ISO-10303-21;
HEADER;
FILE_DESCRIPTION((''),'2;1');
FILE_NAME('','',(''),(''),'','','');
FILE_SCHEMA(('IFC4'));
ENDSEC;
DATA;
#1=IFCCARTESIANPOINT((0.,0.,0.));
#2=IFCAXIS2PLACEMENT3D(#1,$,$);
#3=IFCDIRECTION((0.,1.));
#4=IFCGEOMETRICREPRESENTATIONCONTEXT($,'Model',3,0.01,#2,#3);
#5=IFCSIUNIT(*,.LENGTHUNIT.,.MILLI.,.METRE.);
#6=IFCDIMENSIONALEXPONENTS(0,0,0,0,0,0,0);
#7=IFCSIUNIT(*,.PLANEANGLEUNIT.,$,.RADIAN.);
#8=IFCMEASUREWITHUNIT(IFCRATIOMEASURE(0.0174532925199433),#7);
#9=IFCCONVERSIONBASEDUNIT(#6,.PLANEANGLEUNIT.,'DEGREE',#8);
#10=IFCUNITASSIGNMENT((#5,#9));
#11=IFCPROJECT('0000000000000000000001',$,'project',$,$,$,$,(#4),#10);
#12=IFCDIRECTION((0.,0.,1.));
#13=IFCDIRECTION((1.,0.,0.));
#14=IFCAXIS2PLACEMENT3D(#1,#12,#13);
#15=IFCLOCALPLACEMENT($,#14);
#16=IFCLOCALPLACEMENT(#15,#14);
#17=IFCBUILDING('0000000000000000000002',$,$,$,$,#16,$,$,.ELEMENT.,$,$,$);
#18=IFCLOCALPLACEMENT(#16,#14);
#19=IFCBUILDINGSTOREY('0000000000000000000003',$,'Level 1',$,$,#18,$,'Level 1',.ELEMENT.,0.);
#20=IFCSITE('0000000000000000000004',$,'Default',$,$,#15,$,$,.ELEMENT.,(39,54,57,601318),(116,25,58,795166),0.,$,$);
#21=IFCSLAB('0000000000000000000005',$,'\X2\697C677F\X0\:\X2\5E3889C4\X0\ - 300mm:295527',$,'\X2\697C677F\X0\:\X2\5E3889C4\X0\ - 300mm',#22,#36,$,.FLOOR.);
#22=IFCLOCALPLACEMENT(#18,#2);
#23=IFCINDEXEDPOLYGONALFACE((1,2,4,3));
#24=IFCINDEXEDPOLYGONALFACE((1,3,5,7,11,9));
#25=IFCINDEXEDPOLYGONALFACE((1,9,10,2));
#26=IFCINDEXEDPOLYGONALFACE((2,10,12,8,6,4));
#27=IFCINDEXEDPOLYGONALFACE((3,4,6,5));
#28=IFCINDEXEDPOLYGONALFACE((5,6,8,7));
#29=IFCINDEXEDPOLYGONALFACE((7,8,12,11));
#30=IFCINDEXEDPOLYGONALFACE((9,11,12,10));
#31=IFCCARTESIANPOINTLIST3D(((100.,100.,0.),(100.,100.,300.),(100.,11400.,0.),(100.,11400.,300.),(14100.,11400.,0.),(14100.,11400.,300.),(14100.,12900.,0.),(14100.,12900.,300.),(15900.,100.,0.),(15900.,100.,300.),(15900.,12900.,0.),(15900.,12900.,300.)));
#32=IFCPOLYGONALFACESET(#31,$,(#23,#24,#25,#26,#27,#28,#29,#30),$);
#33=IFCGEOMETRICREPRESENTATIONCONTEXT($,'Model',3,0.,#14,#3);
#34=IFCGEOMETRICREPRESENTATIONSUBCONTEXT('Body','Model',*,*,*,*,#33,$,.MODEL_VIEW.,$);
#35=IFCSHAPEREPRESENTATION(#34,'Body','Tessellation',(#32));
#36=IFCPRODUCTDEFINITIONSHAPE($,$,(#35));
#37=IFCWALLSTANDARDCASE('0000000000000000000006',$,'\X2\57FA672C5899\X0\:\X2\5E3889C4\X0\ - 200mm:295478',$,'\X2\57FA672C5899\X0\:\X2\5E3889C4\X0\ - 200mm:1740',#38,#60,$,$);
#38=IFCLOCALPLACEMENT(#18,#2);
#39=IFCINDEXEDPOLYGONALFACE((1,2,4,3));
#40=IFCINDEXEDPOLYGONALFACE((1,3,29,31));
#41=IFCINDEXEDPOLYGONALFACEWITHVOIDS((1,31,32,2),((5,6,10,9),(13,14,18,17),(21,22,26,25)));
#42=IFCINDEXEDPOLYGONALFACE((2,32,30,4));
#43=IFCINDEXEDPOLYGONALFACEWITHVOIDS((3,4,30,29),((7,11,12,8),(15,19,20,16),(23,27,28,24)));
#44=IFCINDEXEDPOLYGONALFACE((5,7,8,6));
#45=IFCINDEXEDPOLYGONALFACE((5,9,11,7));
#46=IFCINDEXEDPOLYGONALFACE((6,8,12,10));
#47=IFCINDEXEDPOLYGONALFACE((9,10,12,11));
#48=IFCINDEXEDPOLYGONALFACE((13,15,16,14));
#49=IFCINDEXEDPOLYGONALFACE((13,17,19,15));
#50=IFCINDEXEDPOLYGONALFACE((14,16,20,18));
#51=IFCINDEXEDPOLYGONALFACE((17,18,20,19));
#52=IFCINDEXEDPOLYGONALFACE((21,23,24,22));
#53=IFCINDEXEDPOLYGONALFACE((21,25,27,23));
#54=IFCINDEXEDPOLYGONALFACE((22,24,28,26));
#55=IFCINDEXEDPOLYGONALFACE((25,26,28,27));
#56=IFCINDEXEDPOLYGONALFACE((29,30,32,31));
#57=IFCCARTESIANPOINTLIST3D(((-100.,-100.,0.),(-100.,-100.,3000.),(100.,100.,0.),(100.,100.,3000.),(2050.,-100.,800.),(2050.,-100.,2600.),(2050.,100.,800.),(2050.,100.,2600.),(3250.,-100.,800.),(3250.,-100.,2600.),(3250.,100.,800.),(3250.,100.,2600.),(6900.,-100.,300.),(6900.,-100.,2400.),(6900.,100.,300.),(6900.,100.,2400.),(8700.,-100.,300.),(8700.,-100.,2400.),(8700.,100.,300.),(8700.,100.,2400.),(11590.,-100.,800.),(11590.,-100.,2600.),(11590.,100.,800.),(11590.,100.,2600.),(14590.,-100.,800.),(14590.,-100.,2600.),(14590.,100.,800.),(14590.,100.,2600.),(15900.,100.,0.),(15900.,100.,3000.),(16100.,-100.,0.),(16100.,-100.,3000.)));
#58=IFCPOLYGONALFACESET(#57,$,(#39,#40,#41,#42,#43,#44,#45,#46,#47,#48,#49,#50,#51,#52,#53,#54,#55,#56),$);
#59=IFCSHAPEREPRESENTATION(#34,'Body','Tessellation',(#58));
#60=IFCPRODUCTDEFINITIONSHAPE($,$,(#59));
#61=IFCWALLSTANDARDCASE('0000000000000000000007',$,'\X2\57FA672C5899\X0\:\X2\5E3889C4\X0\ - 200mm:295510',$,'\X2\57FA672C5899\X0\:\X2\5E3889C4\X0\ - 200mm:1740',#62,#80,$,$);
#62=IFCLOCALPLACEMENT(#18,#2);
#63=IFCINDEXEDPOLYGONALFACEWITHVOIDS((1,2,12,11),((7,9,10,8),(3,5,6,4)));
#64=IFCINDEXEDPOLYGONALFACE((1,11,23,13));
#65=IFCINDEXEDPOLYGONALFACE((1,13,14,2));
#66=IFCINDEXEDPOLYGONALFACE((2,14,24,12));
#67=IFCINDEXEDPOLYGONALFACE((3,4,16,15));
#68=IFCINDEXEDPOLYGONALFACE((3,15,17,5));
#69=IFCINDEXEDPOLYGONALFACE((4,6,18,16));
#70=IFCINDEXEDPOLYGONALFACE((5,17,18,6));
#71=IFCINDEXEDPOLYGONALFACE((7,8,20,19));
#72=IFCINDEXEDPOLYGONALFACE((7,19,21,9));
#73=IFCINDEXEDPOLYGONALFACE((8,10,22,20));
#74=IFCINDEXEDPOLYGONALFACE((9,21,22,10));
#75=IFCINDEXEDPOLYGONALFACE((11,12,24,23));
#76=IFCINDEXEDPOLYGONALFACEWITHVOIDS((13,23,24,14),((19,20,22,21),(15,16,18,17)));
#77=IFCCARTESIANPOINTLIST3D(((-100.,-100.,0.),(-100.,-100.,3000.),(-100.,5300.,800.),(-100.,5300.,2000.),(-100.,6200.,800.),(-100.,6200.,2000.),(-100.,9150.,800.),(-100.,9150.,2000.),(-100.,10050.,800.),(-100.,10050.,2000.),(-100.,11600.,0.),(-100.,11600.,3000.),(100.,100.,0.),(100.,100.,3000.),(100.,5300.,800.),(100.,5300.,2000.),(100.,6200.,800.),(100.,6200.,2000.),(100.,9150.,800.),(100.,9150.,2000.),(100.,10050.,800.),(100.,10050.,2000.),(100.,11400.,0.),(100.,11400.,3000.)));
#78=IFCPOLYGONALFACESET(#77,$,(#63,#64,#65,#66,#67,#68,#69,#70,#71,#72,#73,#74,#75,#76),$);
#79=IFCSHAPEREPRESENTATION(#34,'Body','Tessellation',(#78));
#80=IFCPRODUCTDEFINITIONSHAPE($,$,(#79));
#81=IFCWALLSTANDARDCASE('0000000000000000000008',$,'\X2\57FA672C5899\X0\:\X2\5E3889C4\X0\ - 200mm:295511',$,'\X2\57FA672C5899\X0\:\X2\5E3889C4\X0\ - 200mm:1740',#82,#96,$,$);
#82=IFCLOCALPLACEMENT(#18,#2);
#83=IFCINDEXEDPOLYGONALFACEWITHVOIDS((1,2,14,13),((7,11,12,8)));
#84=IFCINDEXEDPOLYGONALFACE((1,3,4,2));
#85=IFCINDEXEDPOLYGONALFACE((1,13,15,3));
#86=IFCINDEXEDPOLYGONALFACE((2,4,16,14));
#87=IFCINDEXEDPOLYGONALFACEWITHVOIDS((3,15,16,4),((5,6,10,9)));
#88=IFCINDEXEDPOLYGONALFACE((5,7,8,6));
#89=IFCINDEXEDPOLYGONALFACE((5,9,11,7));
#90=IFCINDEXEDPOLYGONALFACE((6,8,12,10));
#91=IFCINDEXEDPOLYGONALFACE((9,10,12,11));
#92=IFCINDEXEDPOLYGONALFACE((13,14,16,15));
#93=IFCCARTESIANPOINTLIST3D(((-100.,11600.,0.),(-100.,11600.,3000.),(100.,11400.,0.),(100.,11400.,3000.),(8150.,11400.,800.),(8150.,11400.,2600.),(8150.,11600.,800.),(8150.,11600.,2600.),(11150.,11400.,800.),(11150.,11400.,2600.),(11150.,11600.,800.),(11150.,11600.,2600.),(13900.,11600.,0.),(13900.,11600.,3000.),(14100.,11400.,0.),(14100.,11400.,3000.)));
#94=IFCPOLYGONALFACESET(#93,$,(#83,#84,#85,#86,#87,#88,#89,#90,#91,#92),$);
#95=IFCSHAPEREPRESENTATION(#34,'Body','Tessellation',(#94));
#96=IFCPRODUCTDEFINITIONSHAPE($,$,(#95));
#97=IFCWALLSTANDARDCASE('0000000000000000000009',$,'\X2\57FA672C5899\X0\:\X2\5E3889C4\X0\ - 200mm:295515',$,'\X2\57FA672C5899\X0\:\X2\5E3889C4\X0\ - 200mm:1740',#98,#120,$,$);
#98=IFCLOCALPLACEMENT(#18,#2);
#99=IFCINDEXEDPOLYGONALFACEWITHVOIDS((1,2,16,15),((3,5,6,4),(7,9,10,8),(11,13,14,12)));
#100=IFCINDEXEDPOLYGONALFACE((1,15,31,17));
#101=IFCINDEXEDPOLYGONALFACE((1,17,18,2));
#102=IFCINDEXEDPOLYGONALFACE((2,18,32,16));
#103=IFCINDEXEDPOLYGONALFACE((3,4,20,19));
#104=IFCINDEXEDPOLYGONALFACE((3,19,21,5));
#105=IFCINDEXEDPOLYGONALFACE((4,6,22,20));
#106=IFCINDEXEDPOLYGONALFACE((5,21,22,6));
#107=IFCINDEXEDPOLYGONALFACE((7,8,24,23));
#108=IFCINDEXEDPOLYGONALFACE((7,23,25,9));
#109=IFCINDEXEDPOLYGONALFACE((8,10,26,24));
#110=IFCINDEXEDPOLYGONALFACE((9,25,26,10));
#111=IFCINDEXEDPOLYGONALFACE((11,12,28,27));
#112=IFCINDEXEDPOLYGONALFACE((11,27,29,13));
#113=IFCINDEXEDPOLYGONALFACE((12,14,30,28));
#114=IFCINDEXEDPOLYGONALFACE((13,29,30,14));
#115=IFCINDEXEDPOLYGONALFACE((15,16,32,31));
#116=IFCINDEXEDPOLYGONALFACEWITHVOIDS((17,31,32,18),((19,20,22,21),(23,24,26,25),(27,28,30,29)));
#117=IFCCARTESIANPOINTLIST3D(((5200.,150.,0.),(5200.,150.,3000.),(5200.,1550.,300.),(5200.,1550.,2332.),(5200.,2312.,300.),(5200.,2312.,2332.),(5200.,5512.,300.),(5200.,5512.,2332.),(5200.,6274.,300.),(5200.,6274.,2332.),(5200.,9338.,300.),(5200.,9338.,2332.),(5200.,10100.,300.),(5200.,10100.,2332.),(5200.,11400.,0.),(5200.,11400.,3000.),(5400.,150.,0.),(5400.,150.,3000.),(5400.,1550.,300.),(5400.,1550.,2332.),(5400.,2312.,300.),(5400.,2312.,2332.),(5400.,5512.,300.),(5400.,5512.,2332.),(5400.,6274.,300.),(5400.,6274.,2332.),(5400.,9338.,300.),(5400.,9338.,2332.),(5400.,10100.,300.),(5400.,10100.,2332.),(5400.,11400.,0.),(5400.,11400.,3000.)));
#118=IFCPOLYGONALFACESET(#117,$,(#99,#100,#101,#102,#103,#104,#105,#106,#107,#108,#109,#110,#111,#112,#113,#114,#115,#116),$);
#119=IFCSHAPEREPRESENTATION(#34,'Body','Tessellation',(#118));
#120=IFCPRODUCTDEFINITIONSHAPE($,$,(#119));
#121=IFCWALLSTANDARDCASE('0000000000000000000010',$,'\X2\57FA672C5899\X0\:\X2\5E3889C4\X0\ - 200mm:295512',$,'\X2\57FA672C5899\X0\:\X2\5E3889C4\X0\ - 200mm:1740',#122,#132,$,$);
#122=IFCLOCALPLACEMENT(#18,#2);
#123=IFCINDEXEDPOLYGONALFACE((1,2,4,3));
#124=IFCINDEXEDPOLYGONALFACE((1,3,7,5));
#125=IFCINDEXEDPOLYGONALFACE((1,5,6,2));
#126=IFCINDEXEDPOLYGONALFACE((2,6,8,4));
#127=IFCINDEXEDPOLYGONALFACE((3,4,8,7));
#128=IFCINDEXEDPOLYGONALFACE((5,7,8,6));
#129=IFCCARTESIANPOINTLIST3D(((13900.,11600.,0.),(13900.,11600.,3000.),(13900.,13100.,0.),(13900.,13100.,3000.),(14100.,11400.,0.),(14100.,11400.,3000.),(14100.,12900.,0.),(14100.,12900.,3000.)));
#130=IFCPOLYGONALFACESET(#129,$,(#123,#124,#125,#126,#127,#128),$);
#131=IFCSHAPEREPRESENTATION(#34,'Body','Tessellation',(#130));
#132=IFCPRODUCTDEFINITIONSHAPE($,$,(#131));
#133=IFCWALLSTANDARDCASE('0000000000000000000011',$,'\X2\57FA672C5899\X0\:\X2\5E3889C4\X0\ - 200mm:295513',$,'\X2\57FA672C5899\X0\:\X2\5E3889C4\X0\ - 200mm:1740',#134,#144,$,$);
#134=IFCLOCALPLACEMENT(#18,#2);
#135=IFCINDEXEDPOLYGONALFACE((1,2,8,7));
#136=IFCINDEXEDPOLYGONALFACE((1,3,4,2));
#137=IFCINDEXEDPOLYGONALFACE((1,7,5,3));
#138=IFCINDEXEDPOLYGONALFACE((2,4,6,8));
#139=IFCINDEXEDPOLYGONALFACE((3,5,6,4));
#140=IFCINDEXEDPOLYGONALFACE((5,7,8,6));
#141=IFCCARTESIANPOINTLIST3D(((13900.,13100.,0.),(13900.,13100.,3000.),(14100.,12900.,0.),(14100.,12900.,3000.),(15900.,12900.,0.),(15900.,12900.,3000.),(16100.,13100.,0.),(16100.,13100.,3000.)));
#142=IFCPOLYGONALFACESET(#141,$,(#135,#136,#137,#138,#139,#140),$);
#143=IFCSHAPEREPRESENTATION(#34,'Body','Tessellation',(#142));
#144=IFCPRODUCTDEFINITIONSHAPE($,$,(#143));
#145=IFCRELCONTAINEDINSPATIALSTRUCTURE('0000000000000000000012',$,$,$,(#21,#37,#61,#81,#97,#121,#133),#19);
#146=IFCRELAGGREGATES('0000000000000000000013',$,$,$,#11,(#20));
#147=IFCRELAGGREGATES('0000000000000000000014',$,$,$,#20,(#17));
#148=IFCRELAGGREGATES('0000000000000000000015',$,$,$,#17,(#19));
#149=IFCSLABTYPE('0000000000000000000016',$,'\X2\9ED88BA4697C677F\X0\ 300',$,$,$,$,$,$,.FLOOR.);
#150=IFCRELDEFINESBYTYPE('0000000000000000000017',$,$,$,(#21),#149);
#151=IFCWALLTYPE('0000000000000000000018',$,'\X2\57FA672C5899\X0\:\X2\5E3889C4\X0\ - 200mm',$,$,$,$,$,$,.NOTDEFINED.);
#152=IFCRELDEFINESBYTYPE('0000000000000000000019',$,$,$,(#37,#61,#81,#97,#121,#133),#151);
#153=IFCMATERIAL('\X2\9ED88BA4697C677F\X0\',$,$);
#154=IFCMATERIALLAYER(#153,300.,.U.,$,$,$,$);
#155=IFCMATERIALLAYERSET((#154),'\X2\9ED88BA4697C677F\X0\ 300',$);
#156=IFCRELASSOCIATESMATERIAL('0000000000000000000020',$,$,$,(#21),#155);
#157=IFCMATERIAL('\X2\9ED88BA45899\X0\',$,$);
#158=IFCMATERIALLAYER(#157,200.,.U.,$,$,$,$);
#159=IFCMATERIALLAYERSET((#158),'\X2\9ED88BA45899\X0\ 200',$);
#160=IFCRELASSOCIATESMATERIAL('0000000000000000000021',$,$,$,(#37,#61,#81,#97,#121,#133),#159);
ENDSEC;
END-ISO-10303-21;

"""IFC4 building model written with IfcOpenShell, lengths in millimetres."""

from ifc_helpers import new_model, entity, si_unit, converted_unit, direction, frame, origin, origin_with_axes, place, context, subcontext, project, spatial, polyline, outline, extrude, material, layer, layer_set, layer_usage, type_object, element, save


model = new_model("IFC4")

# Units and contexts
model_context_1 = context("Model", 3, precision=0.01, world=origin(), true_north=direction((0.0, 1.0)))
model_context_2 = context("Model", 3, precision=0.0, world=origin_with_axes(), true_north=direction((0.0, 1.0)))
body_context = subcontext(model_context_2, "Body", "Model", "MODEL_VIEW")
ifc_project = project(units=[si_unit("LENGTHUNIT", "METRE", prefix="MILLI"), converted_unit("PLANEANGLEUNIT", "DEGREE", entity("IfcRatioMeasure", 0.0174532925199433), si_unit("PLANEANGLEUNIT", "RADIAN"), dimensions=[0, 0, 0, 0, 0, 0, 0])], contexts=[model_context_1])

# Site, building, storey
site_placement = place(None, origin_with_axes())
site = spatial("IfcSite", under=ifc_project, at=site_placement, Name="Default", CompositionType="ELEMENT", RefLatitude=(39, 54, 57, 601318), RefLongitude=(116, 25, 58, 795166), RefElevation=0.0)
building_placement = place(site_placement, origin_with_axes())
building = spatial("IfcBuilding", under=site, at=building_placement, CompositionType="ELEMENT")
storey_placement = place(building_placement, origin_with_axes())
storey = spatial("IfcBuildingStorey", under=building, at=storey_placement, Name="Level 1", LongName="Level 1", CompositionType="ELEMENT", Elevation=0.0)

# Slab
ifc_material_1 = material(Name="默认楼板")
ifc_layer_1 = layer(ifc_material_1, 300.0, ventilated="UNKNOWN")
ifc_layer_set_1 = layer_set([ifc_layer_1], Name="默认楼板 300")
ifc_layer_usage_1 = layer_usage(ifc_layer_set_1, "AXIS3", "NEGATIVE", 300.0)
slab_type = type_object("IfcSlabType", Name="默认楼板 300", PredefinedType="FLOOR")
slab_placement = place(storey_placement, frame((100.0, 100.0, 0.0), z_axis=(0.0, 0.0, 1.0), x_axis=(1.0, 0.0, 0.0)))
element("IfcSlab", 1, at=slab_placement, inside=storey, type_object=slab_type, material=ifc_layer_usage_1, Name="楼板:常规 - 300mm:295527", ObjectType="楼板:常规 - 300mm", PredefinedType="FLOOR", context=body_context, shape_type="SweptSolid", body=[
    extrude(outline(polyline([(0.0, 0.0), (15800.0, 0.0), (15800.0, 12800.0), (14000.0, 12800.0), (14000.0, 11300.0), (0.0, 11300.0), (0.0, 0.0)])), origin_with_axes(), (0.0, 0.0, 1.0), 300.0),
])

# Walls, openings
ifc_material_2 = material(Name="默认墙")
ifc_layer_2 = layer(ifc_material_2, 200.0, ventilated="UNKNOWN")
ifc_layer_set_2 = layer_set([ifc_layer_2], Name="默认墙 200")
ifc_layer_usage_2 = layer_usage(ifc_layer_set_2, "AXIS2", "POSITIVE", -100.0)
wall_type = type_object("IfcWallType", Name="基本墙:常规 - 200mm", PredefinedType="NOTDEFINED")
wall_1_placement = place(storey_placement, frame((16000.0, 0.0, 0.0), z_axis=(0.0, 0.0, 1.0), x_axis=(-1.0, 0.0, 0.0)))
wall_1 = element("IfcWallStandardCase", 2, at=wall_1_placement, inside=storey, type_object=wall_type, material=ifc_layer_usage_2, Name="基本墙:常规 - 200mm:295478", ObjectType="基本墙:常规 - 200mm:1740", context=body_context, shape_type="SweptSolid", body=[
    extrude(outline(polyline([(100.0, -100.0), (15900.0, -100.0), (16100.0, 100.0), (-100.0, 100.0), (100.0, -100.0)])), origin_with_axes(), (0.0, 0.0, 1.0), 3000.0),
])
opening_1_placement = place(wall_1_placement, frame((13350.0, 0.0, 800.0), z_axis=(0.0, 0.0, 1.0), x_axis=(1.0, 0.0, 0.0)))
element("IfcOpeningElement", 3, at=opening_1_placement, cuts=wall_1, context=body_context, shape_type="SweptSolid", body=[
    extrude(outline(polyline([(-600.0, 0.0), (-600.0, -1800.0), (600.0, -1800.0), (600.0, 0.0), (-600.0, 0.0)])), frame((0.0, -100.0, 0.0), z_axis=(0.0, 1.0, 0.0), x_axis=(1.0, 0.0, 0.0)), (0.0, 0.0, 1.0), 200.0),
])
opening_2_placement = place(wall_1_placement, frame((2910.0, 0.0, 800.0), z_axis=(0.0, 0.0, 1.0), x_axis=(1.0, 0.0, 0.0)))
element("IfcOpeningElement", 4, at=opening_2_placement, cuts=wall_1, context=body_context, shape_type="SweptSolid", body=[
    extrude(outline(polyline([(-1500.0, 0.0), (-1500.0, -1800.0), (1500.0, -1800.0), (1500.0, 0.0), (-1500.0, 0.0)])), frame((0.0, -100.0, 0.0), z_axis=(0.0, 1.0, 0.0), x_axis=(1.0, 0.0, 0.0)), (0.0, 0.0, 1.0), 200.0),
])
opening_3_placement = place(wall_1_placement, frame((8200.0, 0.0, 300.0), z_axis=(0.0, 0.0, 1.0), x_axis=(1.0, 0.0, 0.0)))
element("IfcOpeningElement", 5, at=opening_3_placement, cuts=wall_1, context=body_context, shape_type="SweptSolid", body=[
    extrude(outline(polyline([(-900.0, 0.0), (-900.0, -2100.0), (900.0, -2100.0), (900.0, 0.0), (-900.0, 0.0)])), frame((0.0, -100.0, 0.0), z_axis=(0.0, 1.0, 0.0), x_axis=(1.0, 0.0, 0.0)), (0.0, 0.0, 1.0), 200.0),
])
ifc_layer_usage_3 = layer_usage(ifc_layer_set_2, "AXIS2", "POSITIVE", -100.0)
wall_2_placement = place(storey_placement, frame((0.0, 0.0, 0.0), z_axis=(0.0, 0.0, 1.0), x_axis=(0.0, 1.0, 0.0)))
wall_2 = element("IfcWallStandardCase", 6, at=wall_2_placement, inside=storey, type_object=wall_type, material=ifc_layer_usage_3, Name="基本墙:常规 - 200mm:295510", ObjectType="基本墙:常规 - 200mm:1740", context=body_context, shape_type="SweptSolid", body=[
    extrude(outline(polyline([(100.0, -100.0), (11400.0, -100.0), (11600.0, 100.0), (-100.0, 100.0), (100.0, -100.0)])), origin_with_axes(), (0.0, 0.0, 1.0), 3000.0),
])
opening_4_placement = place(wall_2_placement, frame((5750.0, 0.0, 800.0), z_axis=(0.0, 0.0, 1.0), x_axis=(1.0, 0.0, 0.0)))
element("IfcOpeningElement", 7, at=opening_4_placement, cuts=wall_2, context=body_context, shape_type="SweptSolid", body=[
    extrude(outline(polyline([(450.0, -1200.0), (450.0, 0.0), (-450.0, 0.0), (-450.0, -1200.0), (450.0, -1200.0)])), frame((0.0, 100.0, 0.0), z_axis=(0.0, -1.0, 0.0), x_axis=(-1.0, 0.0, 0.0)), (0.0, 0.0, 1.0), 200.0),
])
opening_5_placement = place(wall_2_placement, frame((9600.0, 0.0, 800.0), z_axis=(0.0, 0.0, 1.0), x_axis=(1.0, 0.0, 0.0)))
element("IfcOpeningElement", 8, at=opening_5_placement, cuts=wall_2, context=body_context, shape_type="SweptSolid", body=[
    extrude(outline(polyline([(450.0, -1200.0), (450.0, 0.0), (-450.0, 0.0), (-450.0, -1200.0), (450.0, -1200.0)])), frame((0.0, 100.0, 0.0), z_axis=(0.0, -1.0, 0.0), x_axis=(-1.0, 0.0, 0.0)), (0.0, 0.0, 1.0), 200.0),
])

# Wall, opening
ifc_layer_usage_4 = layer_usage(ifc_layer_set_2, "AXIS2", "POSITIVE", -100.0)
wall_3_placement = place(storey_placement, frame((0.0, 11500.0, 0.0), z_axis=(0.0, 0.0, 1.0), x_axis=(1.0, 0.0, 0.0)))
wall_3 = element("IfcWallStandardCase", 9, at=wall_3_placement, inside=storey, type_object=wall_type, material=ifc_layer_usage_4, Name="基本墙:常规 - 200mm:295511", ObjectType="基本墙:常规 - 200mm:1740", context=body_context, shape_type="SweptSolid", body=[
    extrude(outline(polyline([(100.0, -100.0), (14100.0, -100.0), (13900.0, 100.0), (-100.0, 100.0), (100.0, -100.0)])), origin_with_axes(), (0.0, 0.0, 1.0), 3000.0),
])
opening_6_placement = place(wall_3_placement, frame((9650.0, 0.0, 800.0), z_axis=(0.0, 0.0, 1.0), x_axis=(1.0, 0.0, 0.0)))
element("IfcOpeningElement", 10, at=opening_6_placement, cuts=wall_3, context=body_context, shape_type="SweptSolid", body=[
    extrude(outline(polyline([(-1500.0, 0.0), (-1500.0, -1800.0), (1500.0, -1800.0), (1500.0, 0.0), (-1500.0, 0.0)])), frame((0.0, -100.0, 0.0), z_axis=(0.0, 1.0, 0.0), x_axis=(1.0, 0.0, 0.0)), (0.0, 0.0, 1.0), 200.0),
])

# Wall, openings
ifc_layer_usage_5 = layer_usage(ifc_layer_set_2, "AXIS2", "POSITIVE", -100.0)
wall_4_placement = place(storey_placement, frame((5300.0, 11500.0, 0.0), z_axis=(0.0, 0.0, 1.0), x_axis=(0.0, -1.0, 0.0)))
wall_4 = element("IfcWallStandardCase", 11, at=wall_4_placement, inside=storey, type_object=wall_type, material=ifc_layer_usage_5, Name="基本墙:常规 - 200mm:295515", ObjectType="基本墙:常规 - 200mm:1740", context=body_context, shape_type="SweptSolid", body=[
    extrude(outline(polyline([(100.0, -100.0), (11350.0, -100.0), (11350.0, 100.0), (100.0, 100.0), (100.0, -100.0)])), origin_with_axes(), (0.0, 0.0, 1.0), 3000.0),
])
opening_7_placement = place(wall_4_placement, frame((1781.0, 0.0, 300.0), z_axis=(0.0, 0.0, 1.0), x_axis=(1.0, 0.0, 0.0)))
element("IfcOpeningElement", 12, at=opening_7_placement, cuts=wall_4, context=body_context, shape_type="SweptSolid", body=[
    extrude(outline(polyline([(-381.0, -2032.0), (381.0, -2032.0), (381.0, 0.0), (-381.0, 0.0), (-381.0, -2032.0)])), frame((0.0, -100.0, 0.0), z_axis=(0.0, 1.0, 0.0), x_axis=(1.0, 0.0, 0.0)), (0.0, 0.0, 1.0), 200.0),
])
opening_8_placement = place(wall_4_placement, frame((9569.0, 0.0, 300.0), z_axis=(0.0, 0.0, 1.0), x_axis=(1.0, 0.0, 0.0)))
element("IfcOpeningElement", 13, at=opening_8_placement, cuts=wall_4, context=body_context, shape_type="SweptSolid", body=[
    extrude(outline(polyline([(-381.0, -2032.0), (381.0, -2032.0), (381.0, 0.0), (-381.0, 0.0), (-381.0, -2032.0)])), frame((0.0, -100.0, 0.0), z_axis=(0.0, 1.0, 0.0), x_axis=(1.0, 0.0, 0.0)), (0.0, 0.0, 1.0), 200.0),
])
opening_9_placement = place(wall_4_placement, frame((5607.0, 0.0, 300.0), z_axis=(0.0, 0.0, 1.0), x_axis=(1.0, 0.0, 0.0)))
element("IfcOpeningElement", 14, at=opening_9_placement, cuts=wall_4, context=body_context, shape_type="SweptSolid", body=[
    extrude(outline(polyline([(-381.0, -2032.0), (381.0, -2032.0), (381.0, 0.0), (-381.0, 0.0), (-381.0, -2032.0)])), frame((0.0, -100.0, 0.0), z_axis=(0.0, 1.0, 0.0), x_axis=(1.0, 0.0, 0.0)), (0.0, 0.0, 1.0), 200.0),
])

# Walls
ifc_layer_usage_6 = layer_usage(ifc_layer_set_2, "AXIS2", "POSITIVE", -100.0)
wall_5_placement = place(storey_placement, frame((14000.0, 11500.0, 0.0), z_axis=(0.0, 0.0, 1.0), x_axis=(0.0, 1.0, 0.0)))
element("IfcWallStandardCase", 15, at=wall_5_placement, inside=storey, type_object=wall_type, material=ifc_layer_usage_6, Name="基本墙:常规 - 200mm:295512", ObjectType="基本墙:常规 - 200mm:1740", context=body_context, shape_type="SweptSolid", body=[
    extrude(outline(polyline([(-100.0, -100.0), (1400.0, -100.0), (1600.0, 100.0), (100.0, 100.0), (-100.0, -100.0)])), origin_with_axes(), (0.0, 0.0, 1.0), 3000.0),
])
ifc_layer_usage_7 = layer_usage(ifc_layer_set_2, "AXIS2", "POSITIVE", -100.0)
wall_6_placement = place(storey_placement, frame((14000.0, 13000.0, 0.0), z_axis=(0.0, 0.0, 1.0), x_axis=(1.0, 0.0, 0.0)))
element("IfcWallStandardCase", 16, at=wall_6_placement, inside=storey, type_object=wall_type, material=ifc_layer_usage_7, Name="基本墙:常规 - 200mm:295513", ObjectType="基本墙:常规 - 200mm:1740", context=body_context, shape_type="SweptSolid", body=[
    extrude(outline(polyline([(100.0, -100.0), (1900.0, -100.0), (2100.0, 100.0), (-100.0, 100.0), (100.0, -100.0)])), origin_with_axes(), (0.0, 0.0, 1.0), 3000.0),
])

save(model, "model.ifc")
